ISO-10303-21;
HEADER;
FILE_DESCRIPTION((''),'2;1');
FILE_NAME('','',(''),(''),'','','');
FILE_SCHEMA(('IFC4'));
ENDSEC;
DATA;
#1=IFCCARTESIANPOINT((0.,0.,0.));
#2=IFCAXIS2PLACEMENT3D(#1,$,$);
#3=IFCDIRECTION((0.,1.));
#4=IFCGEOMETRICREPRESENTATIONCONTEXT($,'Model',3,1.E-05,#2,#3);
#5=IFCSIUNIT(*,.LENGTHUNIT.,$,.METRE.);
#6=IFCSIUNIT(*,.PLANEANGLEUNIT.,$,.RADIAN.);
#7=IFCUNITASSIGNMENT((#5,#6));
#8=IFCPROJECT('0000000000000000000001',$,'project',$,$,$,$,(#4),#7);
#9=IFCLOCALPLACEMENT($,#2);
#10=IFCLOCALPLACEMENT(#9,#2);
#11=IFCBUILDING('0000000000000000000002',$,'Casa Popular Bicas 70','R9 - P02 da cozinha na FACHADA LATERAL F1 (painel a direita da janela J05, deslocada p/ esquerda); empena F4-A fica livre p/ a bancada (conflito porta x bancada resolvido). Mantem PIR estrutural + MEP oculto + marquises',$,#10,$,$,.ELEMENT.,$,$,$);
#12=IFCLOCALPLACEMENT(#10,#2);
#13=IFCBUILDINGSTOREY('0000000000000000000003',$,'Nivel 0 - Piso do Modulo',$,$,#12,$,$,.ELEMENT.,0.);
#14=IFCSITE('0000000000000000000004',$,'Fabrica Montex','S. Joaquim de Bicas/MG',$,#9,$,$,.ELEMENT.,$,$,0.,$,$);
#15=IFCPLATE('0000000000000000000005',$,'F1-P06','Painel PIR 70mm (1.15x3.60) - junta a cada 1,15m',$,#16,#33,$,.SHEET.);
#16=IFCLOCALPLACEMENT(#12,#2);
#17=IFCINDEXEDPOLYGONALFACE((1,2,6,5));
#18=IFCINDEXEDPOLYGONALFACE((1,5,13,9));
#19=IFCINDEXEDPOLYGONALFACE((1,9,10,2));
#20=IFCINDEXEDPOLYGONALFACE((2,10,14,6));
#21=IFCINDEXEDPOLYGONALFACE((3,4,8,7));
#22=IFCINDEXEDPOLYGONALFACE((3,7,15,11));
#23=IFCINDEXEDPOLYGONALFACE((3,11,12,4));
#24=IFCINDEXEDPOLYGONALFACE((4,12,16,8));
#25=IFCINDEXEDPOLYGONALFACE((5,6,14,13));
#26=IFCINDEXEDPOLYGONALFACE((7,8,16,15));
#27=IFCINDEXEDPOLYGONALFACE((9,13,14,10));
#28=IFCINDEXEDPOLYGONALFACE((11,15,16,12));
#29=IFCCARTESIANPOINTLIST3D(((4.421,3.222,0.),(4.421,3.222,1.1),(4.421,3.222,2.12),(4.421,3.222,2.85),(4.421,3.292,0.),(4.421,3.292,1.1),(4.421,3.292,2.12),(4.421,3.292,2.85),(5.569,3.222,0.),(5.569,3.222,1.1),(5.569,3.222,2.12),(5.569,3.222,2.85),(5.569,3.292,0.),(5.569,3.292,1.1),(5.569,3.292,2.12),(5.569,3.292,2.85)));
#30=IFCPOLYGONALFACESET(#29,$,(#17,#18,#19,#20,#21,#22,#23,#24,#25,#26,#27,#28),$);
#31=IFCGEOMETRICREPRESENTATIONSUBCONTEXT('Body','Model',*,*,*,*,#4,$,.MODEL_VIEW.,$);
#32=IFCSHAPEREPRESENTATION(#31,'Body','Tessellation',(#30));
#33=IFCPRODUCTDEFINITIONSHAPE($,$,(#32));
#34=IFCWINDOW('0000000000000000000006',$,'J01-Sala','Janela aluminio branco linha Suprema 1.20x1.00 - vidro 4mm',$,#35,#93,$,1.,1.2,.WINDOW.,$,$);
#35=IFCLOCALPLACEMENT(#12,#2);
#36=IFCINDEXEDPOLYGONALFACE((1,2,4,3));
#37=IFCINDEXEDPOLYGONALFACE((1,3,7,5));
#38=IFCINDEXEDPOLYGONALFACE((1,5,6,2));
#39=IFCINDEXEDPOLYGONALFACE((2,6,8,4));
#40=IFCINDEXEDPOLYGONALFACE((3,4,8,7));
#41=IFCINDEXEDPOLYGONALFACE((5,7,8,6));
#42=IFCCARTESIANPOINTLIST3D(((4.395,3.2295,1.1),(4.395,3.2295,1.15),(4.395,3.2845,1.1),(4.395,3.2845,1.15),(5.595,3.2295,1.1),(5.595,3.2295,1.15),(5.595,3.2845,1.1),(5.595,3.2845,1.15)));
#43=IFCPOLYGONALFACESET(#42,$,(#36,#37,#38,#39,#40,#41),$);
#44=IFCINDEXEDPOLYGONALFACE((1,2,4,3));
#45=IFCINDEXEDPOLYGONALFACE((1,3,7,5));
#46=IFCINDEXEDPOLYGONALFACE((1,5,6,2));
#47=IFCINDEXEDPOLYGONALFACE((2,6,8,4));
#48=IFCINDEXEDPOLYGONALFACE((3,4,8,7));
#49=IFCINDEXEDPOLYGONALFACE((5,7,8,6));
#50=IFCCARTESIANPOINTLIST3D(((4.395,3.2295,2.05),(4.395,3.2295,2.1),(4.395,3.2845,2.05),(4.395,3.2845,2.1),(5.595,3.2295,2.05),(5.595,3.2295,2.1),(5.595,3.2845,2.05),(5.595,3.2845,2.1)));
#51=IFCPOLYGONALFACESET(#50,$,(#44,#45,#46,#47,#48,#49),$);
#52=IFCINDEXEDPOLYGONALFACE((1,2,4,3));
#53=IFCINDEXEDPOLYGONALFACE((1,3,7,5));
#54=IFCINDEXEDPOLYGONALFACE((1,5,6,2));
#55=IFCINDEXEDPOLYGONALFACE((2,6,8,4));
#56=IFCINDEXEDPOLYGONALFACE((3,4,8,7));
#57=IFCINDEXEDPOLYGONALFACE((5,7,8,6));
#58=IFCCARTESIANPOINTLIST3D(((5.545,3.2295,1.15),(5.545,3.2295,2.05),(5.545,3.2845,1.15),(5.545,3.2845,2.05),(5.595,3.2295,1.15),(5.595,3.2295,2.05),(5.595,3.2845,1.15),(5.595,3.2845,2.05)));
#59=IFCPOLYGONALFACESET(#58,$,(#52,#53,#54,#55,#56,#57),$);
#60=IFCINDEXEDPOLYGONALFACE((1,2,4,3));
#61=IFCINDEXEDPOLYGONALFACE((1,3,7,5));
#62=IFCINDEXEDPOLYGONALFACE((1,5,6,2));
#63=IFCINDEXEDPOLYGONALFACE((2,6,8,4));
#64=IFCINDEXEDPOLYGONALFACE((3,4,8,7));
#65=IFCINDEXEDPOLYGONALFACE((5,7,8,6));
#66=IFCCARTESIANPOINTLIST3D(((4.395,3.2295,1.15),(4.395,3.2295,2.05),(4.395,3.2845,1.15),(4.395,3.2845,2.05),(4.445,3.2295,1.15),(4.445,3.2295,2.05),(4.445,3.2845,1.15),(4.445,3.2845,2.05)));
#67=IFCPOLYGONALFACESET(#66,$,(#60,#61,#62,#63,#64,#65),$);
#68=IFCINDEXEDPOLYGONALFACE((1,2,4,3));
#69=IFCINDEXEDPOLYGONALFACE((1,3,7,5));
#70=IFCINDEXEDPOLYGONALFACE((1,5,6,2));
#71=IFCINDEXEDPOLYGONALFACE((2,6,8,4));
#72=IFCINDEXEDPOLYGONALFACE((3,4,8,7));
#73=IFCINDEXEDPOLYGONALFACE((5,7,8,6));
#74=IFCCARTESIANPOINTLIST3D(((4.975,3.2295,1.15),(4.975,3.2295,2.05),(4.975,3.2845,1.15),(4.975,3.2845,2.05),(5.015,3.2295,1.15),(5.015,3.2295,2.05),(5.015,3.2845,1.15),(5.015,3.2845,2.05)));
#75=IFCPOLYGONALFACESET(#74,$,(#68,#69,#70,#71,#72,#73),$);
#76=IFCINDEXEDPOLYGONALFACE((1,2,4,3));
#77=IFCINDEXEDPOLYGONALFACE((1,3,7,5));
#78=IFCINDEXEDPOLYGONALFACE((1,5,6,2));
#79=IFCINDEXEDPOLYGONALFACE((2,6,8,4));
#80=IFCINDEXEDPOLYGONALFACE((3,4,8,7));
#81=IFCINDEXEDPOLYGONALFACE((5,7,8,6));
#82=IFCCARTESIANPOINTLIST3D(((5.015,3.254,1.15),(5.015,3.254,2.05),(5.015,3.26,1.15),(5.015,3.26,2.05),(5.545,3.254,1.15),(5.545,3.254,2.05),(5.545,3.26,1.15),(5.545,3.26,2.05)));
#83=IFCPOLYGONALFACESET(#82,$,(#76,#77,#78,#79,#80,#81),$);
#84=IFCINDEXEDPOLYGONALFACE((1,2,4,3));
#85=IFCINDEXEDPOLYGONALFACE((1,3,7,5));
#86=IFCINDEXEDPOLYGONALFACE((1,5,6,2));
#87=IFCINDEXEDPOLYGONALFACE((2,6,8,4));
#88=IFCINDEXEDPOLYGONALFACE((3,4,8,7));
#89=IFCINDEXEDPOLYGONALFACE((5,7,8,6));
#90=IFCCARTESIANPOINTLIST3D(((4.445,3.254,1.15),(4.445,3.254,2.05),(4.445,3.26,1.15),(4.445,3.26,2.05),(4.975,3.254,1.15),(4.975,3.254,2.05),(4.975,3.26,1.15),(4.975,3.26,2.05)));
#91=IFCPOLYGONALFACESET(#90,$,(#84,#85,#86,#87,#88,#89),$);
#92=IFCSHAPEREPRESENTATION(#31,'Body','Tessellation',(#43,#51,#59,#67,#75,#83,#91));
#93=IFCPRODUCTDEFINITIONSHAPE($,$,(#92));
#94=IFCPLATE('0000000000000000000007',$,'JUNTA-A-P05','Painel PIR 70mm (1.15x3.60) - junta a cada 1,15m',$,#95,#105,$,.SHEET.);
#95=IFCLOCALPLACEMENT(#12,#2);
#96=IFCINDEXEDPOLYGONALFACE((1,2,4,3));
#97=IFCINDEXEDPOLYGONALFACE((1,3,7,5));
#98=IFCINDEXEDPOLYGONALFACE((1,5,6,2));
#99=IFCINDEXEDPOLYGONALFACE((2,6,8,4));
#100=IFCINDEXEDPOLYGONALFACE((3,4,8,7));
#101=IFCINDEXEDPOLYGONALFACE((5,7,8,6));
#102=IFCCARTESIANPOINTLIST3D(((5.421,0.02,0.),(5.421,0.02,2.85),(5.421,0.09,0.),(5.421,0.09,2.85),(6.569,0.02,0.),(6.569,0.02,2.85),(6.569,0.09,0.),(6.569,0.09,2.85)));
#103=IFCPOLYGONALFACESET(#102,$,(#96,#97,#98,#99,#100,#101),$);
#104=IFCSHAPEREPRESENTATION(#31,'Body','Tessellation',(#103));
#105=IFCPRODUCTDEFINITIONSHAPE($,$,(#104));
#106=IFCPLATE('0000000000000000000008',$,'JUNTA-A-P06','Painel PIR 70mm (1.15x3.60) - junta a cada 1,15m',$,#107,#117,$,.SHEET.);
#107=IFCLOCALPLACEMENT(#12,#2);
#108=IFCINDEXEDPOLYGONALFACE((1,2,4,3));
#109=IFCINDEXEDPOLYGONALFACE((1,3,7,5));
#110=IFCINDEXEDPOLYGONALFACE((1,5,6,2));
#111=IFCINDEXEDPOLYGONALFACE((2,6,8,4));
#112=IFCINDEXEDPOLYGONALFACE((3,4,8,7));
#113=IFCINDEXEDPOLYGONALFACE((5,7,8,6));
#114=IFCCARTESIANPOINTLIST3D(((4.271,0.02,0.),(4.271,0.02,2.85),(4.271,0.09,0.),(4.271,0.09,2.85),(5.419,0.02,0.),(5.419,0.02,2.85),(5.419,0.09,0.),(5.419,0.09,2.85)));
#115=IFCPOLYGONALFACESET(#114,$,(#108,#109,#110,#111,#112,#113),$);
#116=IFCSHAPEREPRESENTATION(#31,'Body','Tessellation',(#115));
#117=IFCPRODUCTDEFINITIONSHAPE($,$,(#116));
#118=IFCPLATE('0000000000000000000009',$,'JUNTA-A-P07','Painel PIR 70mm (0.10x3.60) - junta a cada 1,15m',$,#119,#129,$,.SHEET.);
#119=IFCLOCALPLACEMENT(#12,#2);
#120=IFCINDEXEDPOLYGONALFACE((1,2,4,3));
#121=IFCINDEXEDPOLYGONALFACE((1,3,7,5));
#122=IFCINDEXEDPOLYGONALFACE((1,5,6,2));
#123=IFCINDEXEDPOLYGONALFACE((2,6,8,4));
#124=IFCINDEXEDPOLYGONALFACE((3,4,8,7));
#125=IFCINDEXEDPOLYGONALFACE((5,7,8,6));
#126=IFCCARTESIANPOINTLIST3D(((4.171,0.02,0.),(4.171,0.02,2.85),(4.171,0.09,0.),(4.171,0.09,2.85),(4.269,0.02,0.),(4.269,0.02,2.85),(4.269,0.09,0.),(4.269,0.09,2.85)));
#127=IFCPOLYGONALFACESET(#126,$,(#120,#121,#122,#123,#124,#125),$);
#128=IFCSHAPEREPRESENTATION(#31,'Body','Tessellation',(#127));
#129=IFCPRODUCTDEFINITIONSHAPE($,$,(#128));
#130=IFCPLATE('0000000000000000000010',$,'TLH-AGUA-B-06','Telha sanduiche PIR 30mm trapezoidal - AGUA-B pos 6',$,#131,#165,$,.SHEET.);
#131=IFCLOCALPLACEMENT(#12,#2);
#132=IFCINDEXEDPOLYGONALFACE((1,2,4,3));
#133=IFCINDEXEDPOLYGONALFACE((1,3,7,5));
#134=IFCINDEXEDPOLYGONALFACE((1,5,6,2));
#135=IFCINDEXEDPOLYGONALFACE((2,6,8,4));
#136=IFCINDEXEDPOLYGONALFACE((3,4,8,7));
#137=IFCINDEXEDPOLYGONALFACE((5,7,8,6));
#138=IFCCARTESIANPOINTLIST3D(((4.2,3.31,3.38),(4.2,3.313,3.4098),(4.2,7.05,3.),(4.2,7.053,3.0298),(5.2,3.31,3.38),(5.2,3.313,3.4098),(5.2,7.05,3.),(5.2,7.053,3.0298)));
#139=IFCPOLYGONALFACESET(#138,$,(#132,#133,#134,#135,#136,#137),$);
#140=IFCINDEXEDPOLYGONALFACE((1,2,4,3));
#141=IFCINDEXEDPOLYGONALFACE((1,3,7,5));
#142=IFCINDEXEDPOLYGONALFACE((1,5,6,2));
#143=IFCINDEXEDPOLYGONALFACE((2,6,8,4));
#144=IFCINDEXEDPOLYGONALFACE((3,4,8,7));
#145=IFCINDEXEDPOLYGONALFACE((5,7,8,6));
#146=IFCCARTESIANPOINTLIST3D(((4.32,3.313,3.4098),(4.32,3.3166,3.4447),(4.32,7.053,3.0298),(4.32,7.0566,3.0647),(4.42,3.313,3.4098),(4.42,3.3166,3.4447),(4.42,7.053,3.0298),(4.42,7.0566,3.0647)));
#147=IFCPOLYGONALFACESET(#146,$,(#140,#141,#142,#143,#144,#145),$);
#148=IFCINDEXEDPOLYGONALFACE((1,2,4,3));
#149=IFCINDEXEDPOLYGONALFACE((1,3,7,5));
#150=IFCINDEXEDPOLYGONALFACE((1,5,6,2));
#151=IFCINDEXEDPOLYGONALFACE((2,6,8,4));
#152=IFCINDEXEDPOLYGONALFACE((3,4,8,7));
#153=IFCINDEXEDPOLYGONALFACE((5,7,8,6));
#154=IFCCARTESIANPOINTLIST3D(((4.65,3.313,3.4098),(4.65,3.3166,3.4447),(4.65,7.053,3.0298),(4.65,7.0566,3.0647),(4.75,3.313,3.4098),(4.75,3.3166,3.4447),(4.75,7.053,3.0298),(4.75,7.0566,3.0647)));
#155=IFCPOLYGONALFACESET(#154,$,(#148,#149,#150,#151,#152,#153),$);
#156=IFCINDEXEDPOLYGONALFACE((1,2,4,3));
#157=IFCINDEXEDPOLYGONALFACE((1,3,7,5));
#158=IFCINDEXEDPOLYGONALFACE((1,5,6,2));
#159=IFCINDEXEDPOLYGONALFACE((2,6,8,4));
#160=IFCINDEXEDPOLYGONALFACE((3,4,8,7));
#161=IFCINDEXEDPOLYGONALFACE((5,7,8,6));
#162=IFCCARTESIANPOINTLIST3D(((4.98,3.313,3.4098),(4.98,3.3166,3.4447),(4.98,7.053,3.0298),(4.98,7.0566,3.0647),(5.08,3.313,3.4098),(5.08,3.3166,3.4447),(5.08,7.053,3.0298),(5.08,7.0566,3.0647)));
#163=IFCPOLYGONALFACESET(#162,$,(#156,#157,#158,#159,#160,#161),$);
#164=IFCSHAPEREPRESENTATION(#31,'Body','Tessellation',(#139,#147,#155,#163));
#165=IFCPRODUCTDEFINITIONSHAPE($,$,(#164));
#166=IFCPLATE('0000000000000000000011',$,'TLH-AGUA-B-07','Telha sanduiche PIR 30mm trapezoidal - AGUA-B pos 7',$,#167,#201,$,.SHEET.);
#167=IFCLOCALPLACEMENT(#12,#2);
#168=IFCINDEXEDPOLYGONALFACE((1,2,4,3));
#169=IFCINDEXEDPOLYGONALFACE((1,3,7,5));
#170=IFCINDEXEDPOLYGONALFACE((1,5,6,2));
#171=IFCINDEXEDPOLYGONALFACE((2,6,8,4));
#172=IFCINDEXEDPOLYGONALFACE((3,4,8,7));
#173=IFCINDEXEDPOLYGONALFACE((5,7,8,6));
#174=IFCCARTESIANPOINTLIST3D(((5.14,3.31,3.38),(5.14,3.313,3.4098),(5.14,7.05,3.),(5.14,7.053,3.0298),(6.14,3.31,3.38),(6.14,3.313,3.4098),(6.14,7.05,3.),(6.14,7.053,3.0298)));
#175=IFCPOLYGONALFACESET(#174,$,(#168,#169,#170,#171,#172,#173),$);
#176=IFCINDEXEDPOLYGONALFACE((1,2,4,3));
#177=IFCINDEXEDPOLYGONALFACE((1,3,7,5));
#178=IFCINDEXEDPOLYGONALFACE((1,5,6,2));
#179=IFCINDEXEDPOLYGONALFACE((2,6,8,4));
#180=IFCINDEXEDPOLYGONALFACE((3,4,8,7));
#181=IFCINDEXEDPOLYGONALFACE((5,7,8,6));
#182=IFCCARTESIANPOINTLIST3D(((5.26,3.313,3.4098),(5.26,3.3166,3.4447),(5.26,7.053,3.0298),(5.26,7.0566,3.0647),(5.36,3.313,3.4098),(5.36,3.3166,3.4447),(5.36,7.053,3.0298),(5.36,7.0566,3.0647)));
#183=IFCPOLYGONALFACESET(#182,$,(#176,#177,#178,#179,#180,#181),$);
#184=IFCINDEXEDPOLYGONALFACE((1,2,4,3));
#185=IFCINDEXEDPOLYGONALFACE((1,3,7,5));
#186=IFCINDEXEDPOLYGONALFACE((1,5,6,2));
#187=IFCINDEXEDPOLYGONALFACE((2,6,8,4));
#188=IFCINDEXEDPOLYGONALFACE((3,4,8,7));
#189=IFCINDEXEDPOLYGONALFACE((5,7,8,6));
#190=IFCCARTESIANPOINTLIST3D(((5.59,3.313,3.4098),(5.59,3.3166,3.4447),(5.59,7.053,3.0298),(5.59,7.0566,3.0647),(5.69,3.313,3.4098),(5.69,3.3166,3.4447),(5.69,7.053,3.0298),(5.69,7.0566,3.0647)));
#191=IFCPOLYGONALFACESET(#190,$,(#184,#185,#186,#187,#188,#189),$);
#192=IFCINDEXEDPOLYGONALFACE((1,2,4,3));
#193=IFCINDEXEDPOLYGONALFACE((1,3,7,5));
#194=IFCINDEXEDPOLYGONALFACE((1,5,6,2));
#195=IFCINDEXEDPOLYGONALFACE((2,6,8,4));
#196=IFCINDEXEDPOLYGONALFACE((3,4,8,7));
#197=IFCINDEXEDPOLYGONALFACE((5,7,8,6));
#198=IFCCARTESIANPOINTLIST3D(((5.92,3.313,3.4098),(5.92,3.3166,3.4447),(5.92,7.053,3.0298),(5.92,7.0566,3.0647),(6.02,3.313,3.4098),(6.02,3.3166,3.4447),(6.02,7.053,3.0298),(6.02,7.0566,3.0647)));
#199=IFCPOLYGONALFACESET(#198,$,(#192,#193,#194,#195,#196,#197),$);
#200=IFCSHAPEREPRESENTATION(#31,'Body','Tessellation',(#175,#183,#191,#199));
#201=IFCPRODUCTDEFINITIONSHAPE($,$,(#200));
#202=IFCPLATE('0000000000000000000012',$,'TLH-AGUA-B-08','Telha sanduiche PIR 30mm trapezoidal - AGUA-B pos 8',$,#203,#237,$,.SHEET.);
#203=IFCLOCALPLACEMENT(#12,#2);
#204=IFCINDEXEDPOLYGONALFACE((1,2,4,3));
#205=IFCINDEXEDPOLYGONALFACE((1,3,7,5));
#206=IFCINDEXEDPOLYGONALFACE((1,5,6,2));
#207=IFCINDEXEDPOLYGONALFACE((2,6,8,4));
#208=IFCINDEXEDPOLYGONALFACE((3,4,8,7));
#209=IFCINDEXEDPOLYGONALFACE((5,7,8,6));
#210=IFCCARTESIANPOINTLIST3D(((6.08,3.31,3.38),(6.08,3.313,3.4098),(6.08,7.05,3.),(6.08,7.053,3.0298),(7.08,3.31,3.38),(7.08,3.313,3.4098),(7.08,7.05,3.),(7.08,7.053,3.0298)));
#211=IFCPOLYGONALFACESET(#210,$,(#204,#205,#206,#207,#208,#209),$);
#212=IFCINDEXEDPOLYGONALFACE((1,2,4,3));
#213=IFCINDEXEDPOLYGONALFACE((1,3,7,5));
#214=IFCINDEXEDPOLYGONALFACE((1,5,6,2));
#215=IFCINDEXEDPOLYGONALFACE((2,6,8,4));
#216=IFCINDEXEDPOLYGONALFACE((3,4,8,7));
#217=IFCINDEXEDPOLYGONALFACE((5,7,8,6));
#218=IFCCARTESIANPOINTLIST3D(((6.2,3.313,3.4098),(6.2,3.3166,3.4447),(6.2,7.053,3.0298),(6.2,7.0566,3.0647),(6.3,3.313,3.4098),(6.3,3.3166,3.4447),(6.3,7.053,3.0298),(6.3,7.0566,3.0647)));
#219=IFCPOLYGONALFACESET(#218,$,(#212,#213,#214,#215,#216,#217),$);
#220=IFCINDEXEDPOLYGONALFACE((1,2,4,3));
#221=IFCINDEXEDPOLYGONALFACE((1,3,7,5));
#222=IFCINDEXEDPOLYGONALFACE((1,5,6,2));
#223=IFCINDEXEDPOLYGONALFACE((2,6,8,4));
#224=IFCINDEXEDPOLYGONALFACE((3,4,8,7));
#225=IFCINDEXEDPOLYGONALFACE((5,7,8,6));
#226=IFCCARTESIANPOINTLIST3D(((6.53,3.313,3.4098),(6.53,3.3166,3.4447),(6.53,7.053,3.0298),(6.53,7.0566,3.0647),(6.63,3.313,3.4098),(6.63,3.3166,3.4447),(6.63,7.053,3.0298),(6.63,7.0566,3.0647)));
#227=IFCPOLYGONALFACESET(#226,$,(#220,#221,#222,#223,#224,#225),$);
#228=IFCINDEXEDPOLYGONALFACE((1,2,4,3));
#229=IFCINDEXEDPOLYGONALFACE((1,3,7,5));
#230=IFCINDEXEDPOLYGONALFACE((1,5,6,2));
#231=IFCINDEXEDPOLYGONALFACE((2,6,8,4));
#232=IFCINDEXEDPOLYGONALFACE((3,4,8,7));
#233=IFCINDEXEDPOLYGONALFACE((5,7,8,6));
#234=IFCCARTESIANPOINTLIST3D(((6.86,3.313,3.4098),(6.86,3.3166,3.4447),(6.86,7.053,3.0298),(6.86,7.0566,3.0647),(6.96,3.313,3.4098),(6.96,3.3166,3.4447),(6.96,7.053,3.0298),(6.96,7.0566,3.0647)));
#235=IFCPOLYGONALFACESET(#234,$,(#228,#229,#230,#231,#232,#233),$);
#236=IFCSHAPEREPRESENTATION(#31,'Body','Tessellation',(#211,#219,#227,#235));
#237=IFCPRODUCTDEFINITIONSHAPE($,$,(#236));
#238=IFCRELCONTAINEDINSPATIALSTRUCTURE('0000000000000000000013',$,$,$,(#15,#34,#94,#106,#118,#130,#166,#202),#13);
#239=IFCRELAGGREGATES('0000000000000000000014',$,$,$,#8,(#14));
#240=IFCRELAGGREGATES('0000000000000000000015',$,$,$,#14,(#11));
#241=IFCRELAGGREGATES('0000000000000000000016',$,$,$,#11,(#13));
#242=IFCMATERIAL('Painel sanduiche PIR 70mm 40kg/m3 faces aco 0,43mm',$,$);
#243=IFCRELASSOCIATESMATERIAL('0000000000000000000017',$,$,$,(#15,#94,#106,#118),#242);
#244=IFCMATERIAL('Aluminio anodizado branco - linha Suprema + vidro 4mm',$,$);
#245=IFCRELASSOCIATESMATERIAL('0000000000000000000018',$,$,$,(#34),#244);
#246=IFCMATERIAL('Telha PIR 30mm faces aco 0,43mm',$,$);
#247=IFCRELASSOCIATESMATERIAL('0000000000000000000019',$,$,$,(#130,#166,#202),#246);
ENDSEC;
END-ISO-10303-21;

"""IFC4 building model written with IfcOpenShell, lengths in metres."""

from ifc_helpers import new_model, si_unit, direction, frame, frame_2d, origin, place, context, subcontext, project, spatial, rectangle, extrude, material, element, fill, save


model = new_model("IFC4")

# Units and contexts
model_context = context("Model", 3, precision=1e-05, world=origin(), true_north=direction((0.0, 1.0)))
body_context = subcontext(model_context, "Body", "Model", "MODEL_VIEW")
ifc_project = project(units=[si_unit("LENGTHUNIT", "METRE"), si_unit("PLANEANGLEUNIT", "RADIAN")], contexts=[model_context])

# Site, building, storey
site_placement = place(None, origin())
site = spatial("IfcSite", under=ifc_project, at=site_placement, Name="Fabrica Montex", Description="S. Joaquim de Bicas/MG", CompositionType="ELEMENT", RefElevation=0.0)
building_placement = place(site_placement, origin())
building = spatial("IfcBuilding", under=site, at=building_placement, Name="Casa Popular Bicas 70", Description="R9 - P02 da cozinha na FACHADA LATERAL F1 (painel a direita da janela J05, deslocada p/ esquerda); empena F4-A fica livre p/ a bancada (conflito porta x bancada resolvido). Mantem PIR estrutural + MEP oculto + marquises", CompositionType="ELEMENT")
storey_placement = place(building_placement, origin())
storey = spatial("IfcBuildingStorey", under=building, at=storey_placement, Name="Nivel 0 - Piso do Modulo", CompositionType="ELEMENT", Elevation=0.0)

# Shared definitions
ifc_material_1 = material(Name="Painel sanduiche PIR 70mm 40kg/m3 faces aco 0,43mm")

# Plate, opening, window
plate_1_placement = place(None, frame((5.569, 3.257, 0.0), z_axis=(0.0, 0.0, 1.0), x_axis=(-1.0, 0.0, 0.0)))
plate_1 = element("IfcPlate", 1, at=plate_1_placement, inside=storey, material=ifc_material_1, Name="F1-P06", Description="Painel PIR 70mm (1.15x3.60) - junta a cada 1,15m", PredefinedType="SHEET", context=body_context, shape_type="SweptSolid", body=[
    extrude(rectangle(XDim=1.148, YDim=0.07, at=frame_2d((0.574, 0.0))), origin(), (0.0, 0.0, 1.0), 2.85),
])
opening_1_placement = place(None, frame((5.595, 3.257, 1.1), z_axis=(0.0, 0.0, 1.0), x_axis=(-1.0, 0.0, 0.0)))
opening_1 = element("IfcOpeningElement", 2, at=opening_1_placement, cuts=plate_1, PredefinedType="OPENING", context=body_context, shape_type="SweptSolid", body=[
    extrude(rectangle(XDim=1.22, YDim=0.3, at=frame_2d((0.6, 0.0))), origin(), (0.0, 0.0, 1.0), 1.02),
])
ifc_material_2 = material(Name="Aluminio anodizado branco - linha Suprema + vidro 4mm")
window_placement = place(None, frame((5.595, 3.257, 1.1), z_axis=(0.0, 0.0, 1.0), x_axis=(-1.0, 0.0, 0.0)))
window = element("IfcWindow", 3, at=window_placement, inside=storey, material=ifc_material_2, Name="J01-Sala", Description="Janela aluminio branco linha Suprema 1.20x1.00 - vidro 4mm", OverallHeight=1.0, OverallWidth=1.2, PredefinedType="WINDOW", context=body_context, shape_type="SweptSolid", body=[
    extrude(rectangle(XDim=1.2, YDim=0.055, at=frame_2d((0.6, 0.0))), origin(), (0.0, 0.0, 1.0), 0.05),
    extrude(rectangle(XDim=1.2, YDim=0.055, at=frame_2d((0.6, 0.0))), frame((0.0, 0.0, 0.95)), (0.0, 0.0, 1.0), 0.05),
    extrude(rectangle(XDim=0.05, YDim=0.055, at=frame_2d((0.025, 0.0))), frame((0.0, 0.0, 0.05)), (0.0, 0.0, 1.0), 0.9),
    extrude(rectangle(XDim=0.05, YDim=0.055, at=frame_2d((1.175, 0.0))), frame((0.0, 0.0, 0.05)), (0.0, 0.0, 1.0), 0.9),
    extrude(rectangle(XDim=0.04, YDim=0.055, at=frame_2d((0.6, 0.0))), frame((0.0, 0.0, 0.05)), (0.0, 0.0, 1.0), 0.9),
    extrude(rectangle(XDim=0.53, YDim=0.006, at=frame_2d((0.315, 0.0))), frame((0.0, 0.0, 0.05)), (0.0, 0.0, 1.0), 0.9),
    extrude(rectangle(XDim=0.53, YDim=0.006, at=frame_2d((0.885, 0.0))), frame((0.0, 0.0, 0.05)), (0.0, 0.0, 1.0), 0.9),
])
fill(opening_1, window)

# Plates
for number, where, z_axis, x_axis, name in (
    (4, (6.569, 0.055, 0.0), (0.0, 0.0, 1.0), (-1.0, 0.0, 0.0), "JUNTA-A-P05"),
    (5, (5.419, 0.055, 0.0), (0.0, 0.0, 1.0), (-1.0, 0.0, 0.0), "JUNTA-A-P06"),
):
    element("IfcPlate", number, at=place(None, frame(where, z_axis=z_axis, x_axis=x_axis)), inside=storey, material=ifc_material_1, Name=name, Description="Painel PIR 70mm (1.15x3.60) - junta a cada 1,15m", PredefinedType="SHEET", context=body_context, shape_type="SweptSolid", body=[
        extrude(rectangle(XDim=1.148, YDim=0.07, at=frame_2d((0.574, 0.0))), origin(), (0.0, 0.0, 1.0), 2.85),
    ])
plate_2_placement = place(None, frame((4.269, 0.055, 0.0), z_axis=(0.0, 0.0, 1.0), x_axis=(-1.0, 0.0, 0.0)))
element("IfcPlate", 6, at=plate_2_placement, inside=storey, material=ifc_material_1, Name="JUNTA-A-P07", Description="Painel PIR 70mm (0.10x3.60) - junta a cada 1,15m", PredefinedType="SHEET", context=body_context, shape_type="SweptSolid", body=[
    extrude(rectangle(XDim=0.098, YDim=0.07, at=frame_2d((0.049, 0.0))), origin(), (0.0, 0.0, 1.0), 2.85),
])
ifc_material_3 = material(Name="Telha PIR 30mm faces aco 0,43mm")
for number, where, z_axis, x_axis, name, description in (
    (7, (4.2, 3.31, 3.38), (0.0, 0.101084, 0.994878), (1.0, 0.0, 0.0), "TLH-AGUA-B-06", "Telha sanduiche PIR 30mm trapezoidal - AGUA-B pos 6"),
    (8, (5.14, 3.31, 3.38), (0.0, 0.101084, 0.994878), (1.0, 0.0, 0.0), "TLH-AGUA-B-07", "Telha sanduiche PIR 30mm trapezoidal - AGUA-B pos 7"),
    (9, (6.08, 3.31, 3.38), (0.0, 0.101084, 0.994878), (1.0, 0.0, 0.0), "TLH-AGUA-B-08", "Telha sanduiche PIR 30mm trapezoidal - AGUA-B pos 8"),
):
    element("IfcPlate", number, at=place(storey_placement, frame(where, z_axis=z_axis, x_axis=x_axis)), inside=storey, material=ifc_material_3, Name=name, Description=description, PredefinedType="SHEET", context=body_context, shape_type="SweptSolid", body=[
        extrude(rectangle(XDim=1.0, YDim=3.7593, at=frame_2d((0.5, 1.8796))), origin(), (0.0, 0.0, 1.0), 0.03),
        extrude(rectangle(XDim=0.1, YDim=3.7593, at=frame_2d((0.17, 1.8796))), frame((0.0, 0.0, 0.03)), (0.0, 0.0, 1.0), 0.035),
        extrude(rectangle(XDim=0.1, YDim=3.7593, at=frame_2d((0.5, 1.8796))), frame((0.0, 0.0, 0.03)), (0.0, 0.0, 1.0), 0.035),
        extrude(rectangle(XDim=0.1, YDim=3.7593, at=frame_2d((0.83, 1.8796))), frame((0.0, 0.0, 0.03)), (0.0, 0.0, 1.0), 0.035),
    ])

save(model, "model.ifc")
